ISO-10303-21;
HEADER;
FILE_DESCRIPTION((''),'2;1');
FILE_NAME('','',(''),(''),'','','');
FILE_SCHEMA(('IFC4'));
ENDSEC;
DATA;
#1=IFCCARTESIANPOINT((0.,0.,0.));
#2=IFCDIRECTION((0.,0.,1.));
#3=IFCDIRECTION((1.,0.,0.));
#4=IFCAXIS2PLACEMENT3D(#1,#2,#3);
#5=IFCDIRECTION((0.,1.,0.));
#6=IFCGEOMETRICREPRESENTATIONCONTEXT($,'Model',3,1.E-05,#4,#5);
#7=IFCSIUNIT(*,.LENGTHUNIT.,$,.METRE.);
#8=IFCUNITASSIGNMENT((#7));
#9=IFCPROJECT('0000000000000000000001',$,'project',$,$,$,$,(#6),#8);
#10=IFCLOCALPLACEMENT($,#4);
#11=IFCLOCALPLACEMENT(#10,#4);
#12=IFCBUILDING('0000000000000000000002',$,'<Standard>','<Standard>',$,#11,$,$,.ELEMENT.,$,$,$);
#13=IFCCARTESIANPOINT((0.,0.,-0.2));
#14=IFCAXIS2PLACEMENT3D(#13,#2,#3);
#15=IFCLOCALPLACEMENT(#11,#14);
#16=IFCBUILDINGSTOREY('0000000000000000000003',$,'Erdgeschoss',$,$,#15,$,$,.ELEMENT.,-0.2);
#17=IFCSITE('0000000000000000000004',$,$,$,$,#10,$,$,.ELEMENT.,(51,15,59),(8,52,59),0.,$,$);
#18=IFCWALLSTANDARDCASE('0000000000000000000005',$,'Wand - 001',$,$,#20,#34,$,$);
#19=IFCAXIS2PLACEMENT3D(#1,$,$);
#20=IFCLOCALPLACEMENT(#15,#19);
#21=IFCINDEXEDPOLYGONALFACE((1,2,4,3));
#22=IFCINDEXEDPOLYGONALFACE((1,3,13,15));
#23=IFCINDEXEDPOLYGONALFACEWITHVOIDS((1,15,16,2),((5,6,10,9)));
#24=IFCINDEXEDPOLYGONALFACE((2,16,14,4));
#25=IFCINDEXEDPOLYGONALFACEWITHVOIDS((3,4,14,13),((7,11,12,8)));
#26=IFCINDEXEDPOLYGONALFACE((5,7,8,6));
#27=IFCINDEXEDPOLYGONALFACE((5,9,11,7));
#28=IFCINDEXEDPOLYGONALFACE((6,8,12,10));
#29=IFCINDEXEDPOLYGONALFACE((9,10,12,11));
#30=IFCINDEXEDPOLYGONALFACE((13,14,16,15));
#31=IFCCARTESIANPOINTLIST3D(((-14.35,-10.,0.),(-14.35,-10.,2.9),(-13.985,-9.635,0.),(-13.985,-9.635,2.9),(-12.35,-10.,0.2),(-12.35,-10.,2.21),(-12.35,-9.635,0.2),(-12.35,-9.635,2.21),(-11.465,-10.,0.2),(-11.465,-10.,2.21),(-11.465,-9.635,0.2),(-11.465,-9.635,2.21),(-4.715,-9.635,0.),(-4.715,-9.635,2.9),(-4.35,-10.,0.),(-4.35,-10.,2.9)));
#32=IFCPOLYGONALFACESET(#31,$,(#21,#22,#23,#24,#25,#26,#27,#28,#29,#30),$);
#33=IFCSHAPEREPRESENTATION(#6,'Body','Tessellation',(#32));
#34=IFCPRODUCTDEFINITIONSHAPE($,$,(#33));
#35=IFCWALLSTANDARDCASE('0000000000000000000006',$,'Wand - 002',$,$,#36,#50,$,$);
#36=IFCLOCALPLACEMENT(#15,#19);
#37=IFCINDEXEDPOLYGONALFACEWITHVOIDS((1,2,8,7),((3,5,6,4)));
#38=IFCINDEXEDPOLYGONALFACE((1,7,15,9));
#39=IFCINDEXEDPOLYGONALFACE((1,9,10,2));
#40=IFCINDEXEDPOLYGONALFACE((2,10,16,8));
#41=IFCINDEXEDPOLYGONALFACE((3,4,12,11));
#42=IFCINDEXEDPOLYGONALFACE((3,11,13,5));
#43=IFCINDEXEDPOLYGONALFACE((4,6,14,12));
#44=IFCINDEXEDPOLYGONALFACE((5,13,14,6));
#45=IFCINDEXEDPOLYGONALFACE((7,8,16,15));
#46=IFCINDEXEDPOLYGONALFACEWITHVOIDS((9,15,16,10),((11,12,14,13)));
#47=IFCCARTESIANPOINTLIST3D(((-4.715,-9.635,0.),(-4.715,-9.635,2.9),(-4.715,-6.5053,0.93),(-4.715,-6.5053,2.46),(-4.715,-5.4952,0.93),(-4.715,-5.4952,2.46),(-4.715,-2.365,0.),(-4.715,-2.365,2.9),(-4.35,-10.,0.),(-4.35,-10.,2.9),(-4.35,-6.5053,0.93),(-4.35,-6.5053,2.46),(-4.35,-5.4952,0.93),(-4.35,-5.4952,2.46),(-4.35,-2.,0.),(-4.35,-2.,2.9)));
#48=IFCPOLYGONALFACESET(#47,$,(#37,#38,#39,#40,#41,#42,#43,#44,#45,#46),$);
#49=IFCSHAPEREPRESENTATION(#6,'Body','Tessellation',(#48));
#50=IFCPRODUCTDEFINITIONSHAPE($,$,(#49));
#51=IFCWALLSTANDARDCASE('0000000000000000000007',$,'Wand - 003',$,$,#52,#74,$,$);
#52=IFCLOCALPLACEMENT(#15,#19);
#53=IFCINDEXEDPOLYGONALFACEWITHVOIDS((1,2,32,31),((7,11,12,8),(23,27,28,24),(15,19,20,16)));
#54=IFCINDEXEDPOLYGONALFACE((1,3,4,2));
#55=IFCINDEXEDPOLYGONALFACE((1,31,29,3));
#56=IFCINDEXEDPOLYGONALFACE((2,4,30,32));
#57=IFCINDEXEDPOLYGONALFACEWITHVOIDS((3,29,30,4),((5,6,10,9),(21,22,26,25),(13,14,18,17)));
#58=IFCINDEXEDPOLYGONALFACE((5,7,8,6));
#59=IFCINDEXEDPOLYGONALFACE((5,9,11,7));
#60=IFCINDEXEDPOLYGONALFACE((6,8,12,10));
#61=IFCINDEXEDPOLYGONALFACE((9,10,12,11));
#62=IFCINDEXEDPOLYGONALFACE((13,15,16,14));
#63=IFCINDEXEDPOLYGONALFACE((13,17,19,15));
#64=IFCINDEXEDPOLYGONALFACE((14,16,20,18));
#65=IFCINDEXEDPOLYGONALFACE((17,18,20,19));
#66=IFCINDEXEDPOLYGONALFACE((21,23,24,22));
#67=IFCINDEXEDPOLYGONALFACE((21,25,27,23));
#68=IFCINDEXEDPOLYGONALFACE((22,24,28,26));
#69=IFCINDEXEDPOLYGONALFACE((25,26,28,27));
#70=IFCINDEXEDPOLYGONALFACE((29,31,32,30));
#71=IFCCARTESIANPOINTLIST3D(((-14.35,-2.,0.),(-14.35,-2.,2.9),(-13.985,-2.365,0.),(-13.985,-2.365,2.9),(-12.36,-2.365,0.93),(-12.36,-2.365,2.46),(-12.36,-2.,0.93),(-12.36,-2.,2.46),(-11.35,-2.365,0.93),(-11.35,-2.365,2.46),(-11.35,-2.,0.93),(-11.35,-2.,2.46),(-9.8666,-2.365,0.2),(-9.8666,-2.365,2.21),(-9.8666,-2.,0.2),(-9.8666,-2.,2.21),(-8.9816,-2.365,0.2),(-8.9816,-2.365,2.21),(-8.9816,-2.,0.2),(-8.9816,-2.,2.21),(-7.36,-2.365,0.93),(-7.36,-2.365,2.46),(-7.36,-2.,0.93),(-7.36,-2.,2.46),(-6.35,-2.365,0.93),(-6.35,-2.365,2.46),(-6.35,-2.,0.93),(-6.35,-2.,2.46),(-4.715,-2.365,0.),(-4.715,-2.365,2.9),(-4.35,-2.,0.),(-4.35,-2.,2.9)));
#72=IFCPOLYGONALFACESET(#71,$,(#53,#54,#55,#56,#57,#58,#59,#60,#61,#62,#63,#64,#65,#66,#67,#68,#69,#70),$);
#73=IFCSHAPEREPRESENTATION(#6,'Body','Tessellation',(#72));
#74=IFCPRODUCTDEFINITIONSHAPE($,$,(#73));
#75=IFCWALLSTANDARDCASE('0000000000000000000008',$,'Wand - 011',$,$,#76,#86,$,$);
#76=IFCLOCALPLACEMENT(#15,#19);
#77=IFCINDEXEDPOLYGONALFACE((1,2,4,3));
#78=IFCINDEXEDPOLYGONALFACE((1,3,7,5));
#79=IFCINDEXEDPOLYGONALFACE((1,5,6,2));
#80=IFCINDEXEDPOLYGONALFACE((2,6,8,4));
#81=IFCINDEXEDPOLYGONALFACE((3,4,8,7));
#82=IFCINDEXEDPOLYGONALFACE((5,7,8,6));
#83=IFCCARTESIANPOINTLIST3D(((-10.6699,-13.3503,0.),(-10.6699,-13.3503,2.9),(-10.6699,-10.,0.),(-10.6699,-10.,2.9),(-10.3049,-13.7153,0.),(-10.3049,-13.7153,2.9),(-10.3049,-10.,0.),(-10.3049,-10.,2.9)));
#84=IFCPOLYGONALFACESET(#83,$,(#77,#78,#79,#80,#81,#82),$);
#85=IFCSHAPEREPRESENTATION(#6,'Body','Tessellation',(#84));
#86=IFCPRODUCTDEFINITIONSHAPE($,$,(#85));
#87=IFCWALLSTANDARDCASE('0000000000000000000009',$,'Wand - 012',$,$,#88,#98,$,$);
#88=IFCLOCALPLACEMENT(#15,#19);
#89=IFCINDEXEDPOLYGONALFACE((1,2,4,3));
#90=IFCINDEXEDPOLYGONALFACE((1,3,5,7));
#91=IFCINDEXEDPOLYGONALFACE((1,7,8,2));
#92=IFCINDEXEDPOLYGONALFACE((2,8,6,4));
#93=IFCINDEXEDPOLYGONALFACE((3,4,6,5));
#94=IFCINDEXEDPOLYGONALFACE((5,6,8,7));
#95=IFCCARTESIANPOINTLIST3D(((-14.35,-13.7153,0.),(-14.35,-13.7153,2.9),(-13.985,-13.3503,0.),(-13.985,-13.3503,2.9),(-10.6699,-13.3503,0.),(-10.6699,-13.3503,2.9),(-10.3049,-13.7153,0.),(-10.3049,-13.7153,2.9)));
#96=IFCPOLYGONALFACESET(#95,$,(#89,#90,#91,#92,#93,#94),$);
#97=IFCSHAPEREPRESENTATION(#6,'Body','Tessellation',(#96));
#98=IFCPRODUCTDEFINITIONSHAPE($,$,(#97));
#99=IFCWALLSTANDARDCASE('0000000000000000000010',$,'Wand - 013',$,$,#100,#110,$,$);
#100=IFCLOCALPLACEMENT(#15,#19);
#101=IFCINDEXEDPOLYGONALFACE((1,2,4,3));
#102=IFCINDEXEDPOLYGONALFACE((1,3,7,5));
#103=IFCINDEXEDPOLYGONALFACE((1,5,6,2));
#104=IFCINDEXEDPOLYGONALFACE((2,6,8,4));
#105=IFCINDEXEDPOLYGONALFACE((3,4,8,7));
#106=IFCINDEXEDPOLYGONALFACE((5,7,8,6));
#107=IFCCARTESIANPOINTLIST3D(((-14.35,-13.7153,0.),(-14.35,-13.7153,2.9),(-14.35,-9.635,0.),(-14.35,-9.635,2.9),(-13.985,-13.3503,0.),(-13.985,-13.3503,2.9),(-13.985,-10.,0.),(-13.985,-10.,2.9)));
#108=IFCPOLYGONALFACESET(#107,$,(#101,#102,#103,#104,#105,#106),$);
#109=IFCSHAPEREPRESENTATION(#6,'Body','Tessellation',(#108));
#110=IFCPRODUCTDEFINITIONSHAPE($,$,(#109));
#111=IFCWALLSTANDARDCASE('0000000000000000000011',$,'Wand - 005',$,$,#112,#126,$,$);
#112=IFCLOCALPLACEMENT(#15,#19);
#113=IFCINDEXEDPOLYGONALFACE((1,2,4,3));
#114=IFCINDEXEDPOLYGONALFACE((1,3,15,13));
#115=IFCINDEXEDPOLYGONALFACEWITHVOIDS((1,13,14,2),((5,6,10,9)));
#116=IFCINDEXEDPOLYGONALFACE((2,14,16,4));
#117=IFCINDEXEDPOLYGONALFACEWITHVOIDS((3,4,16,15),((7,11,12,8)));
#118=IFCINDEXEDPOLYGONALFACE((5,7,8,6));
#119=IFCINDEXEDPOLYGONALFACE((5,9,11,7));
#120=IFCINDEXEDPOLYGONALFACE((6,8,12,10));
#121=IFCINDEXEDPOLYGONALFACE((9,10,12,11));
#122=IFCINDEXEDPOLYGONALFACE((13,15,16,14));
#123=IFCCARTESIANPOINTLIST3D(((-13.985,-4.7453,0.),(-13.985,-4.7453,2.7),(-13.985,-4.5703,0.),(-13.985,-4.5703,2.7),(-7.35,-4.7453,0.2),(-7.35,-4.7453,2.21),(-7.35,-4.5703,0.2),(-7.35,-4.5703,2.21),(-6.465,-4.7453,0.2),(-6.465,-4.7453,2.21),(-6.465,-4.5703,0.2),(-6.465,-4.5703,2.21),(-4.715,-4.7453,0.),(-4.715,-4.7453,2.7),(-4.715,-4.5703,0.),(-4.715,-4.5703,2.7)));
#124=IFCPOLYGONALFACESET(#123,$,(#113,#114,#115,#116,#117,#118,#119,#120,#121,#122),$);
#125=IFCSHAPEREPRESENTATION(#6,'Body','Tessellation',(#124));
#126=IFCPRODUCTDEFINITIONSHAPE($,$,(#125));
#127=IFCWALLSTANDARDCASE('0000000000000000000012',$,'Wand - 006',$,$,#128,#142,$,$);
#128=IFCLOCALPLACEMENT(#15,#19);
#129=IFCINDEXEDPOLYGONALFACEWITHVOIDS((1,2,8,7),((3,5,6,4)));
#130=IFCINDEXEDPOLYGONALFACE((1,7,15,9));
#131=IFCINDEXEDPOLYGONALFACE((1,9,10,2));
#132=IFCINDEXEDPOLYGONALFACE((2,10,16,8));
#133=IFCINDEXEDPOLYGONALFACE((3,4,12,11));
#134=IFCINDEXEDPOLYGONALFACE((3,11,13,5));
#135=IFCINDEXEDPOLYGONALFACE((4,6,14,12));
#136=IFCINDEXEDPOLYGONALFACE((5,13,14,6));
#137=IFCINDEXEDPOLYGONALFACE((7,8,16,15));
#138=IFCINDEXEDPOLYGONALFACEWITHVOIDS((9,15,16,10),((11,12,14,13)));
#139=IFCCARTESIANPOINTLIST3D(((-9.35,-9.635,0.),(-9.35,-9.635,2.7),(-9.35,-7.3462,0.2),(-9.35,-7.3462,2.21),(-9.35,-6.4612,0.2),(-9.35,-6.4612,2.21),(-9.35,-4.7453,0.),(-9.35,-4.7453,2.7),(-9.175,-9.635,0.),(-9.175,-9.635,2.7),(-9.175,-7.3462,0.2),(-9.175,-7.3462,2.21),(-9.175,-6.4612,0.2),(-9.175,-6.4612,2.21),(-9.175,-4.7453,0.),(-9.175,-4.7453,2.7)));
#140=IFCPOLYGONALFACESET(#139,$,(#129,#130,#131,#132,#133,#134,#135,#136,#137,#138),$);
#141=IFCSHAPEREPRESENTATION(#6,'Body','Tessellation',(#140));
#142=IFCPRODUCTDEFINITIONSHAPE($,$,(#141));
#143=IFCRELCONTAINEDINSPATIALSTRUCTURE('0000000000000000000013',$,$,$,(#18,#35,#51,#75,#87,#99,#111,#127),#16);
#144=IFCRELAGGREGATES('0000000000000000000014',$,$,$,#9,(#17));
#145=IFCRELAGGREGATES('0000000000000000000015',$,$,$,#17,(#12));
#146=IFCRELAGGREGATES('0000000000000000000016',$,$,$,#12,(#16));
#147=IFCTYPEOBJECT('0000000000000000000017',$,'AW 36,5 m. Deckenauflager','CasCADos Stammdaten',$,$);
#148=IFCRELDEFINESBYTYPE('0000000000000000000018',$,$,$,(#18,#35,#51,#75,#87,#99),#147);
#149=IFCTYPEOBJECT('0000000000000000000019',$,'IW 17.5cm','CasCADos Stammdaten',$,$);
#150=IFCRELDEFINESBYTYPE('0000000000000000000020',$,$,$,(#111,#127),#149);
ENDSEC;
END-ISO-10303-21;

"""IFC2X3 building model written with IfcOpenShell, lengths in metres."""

from ifc_helpers import new_model, si_unit, direction, frame, origin_with_axes, place, context, project, spatial, polyline, outline, extrude, type_object, element, save


model = new_model("IFC2X3")

# Units and contexts
model_context = context("Model", 3, precision=1e-05, world=origin_with_axes(), true_north=direction((0.0, 1.0, 0.0)))
ifc_project = project(units=[si_unit("LENGTHUNIT", "METRE")], contexts=[model_context])

# Site, building, storey
site_placement = place(None, origin_with_axes())
site = spatial("IfcSite", under=ifc_project, at=site_placement, CompositionType="ELEMENT", RefLatitude=(51, 15, 59), RefLongitude=(8, 52, 59), RefElevation=0.0)
building_placement = place(site_placement, origin_with_axes())
building = spatial("IfcBuilding", under=site, at=building_placement, Name="<Standard>", Description="<Standard>", CompositionType="ELEMENT")
storey_placement = place(building_placement, frame((0.0, 0.0, -0.2), z_axis=(0.0, 0.0, 1.0), x_axis=(1.0, 0.0, 0.0)))
storey = spatial("IfcBuildingStorey", under=building, at=storey_placement, Name="Erdgeschoss", CompositionType="ELEMENT", Elevation=-0.2)

# Walls, openings
ifc_type_object_1 = type_object("IfcTypeObject", Name="AW 36,5 m. Deckenauflager", Description="CasCADos Stammdaten")
wall_1_placement = place(storey_placement, frame((-14.35, -10.0, 0.0), z_axis=(0.0, 0.0, 1.0), x_axis=(1.0, 0.0, 0.0)))
wall_1 = element("IfcWallStandardCase", 1, at=wall_1_placement, inside=storey, type_object=ifc_type_object_1, Name="Wand - 001", context=model_context, shape_type="SweptSolid", body=[
    extrude(outline(polyline([(0.365, 0.365), (0.0, 0.0), (10.0, 0.0), (9.635, 0.365), (0.365, 0.365)])), origin_with_axes(), (0.0, 0.0, 1.0), 2.9),
])
opening_1_placement = place(wall_1_placement, frame((2.4425, 0.1825, 0.2), z_axis=(0.0, 0.0, 1.0), x_axis=(1.0, 0.0, 0.0)))
element("IfcOpeningElement", 2, at=opening_1_placement, cuts=wall_1, context=model_context, shape_type="SweptSolid", body=[
    extrude(outline(polyline([(0.0, 0.4425), (0.0, -0.4425), (2.01, -0.4425), (2.01, 0.4425), (0.0, 0.4425)])), frame((0.0, -0.1825, 0.0), z_axis=(0.0, 1.0, 0.0), x_axis=(0.0, 0.0, 1.0)), (0.0, 0.0, 1.0), 0.365),
])
wall_2_placement = place(storey_placement, frame((-4.35, -10.0, 0.0), z_axis=(0.0, 0.0, 1.0), x_axis=(0.0, 1.0, 0.0)))
wall_2 = element("IfcWallStandardCase", 3, at=wall_2_placement, inside=storey, type_object=ifc_type_object_1, Name="Wand - 002", context=model_context, shape_type="SweptSolid", body=[
    extrude(outline(polyline([(0.365, 0.365), (0.0, 0.0), (8.0, 0.0), (7.635, 0.365), (0.365, 0.365)])), origin_with_axes(), (0.0, 0.0, 1.0), 2.9),
])
opening_2_placement = place(wall_2_placement, frame((3.9998, 0.1825, 0.2), z_axis=(0.0, 0.0, 1.0), x_axis=(1.0, 0.0, 0.0)))
element("IfcOpeningElement", 4, at=opening_2_placement, cuts=wall_2, context=model_context, shape_type="SweptSolid", body=[
    extrude(outline(polyline([(0.73, 0.505), (0.73, -0.505), (2.26, -0.505), (2.26, 0.505), (0.73, 0.505)])), frame((0.0, -0.1825, 0.0), z_axis=(0.0, 1.0, 0.0), x_axis=(0.0, 0.0, 1.0)), (0.0, 0.0, 1.0), 0.365),
])

# Wall, openings
wall_3_placement = place(storey_placement, frame((-4.35, -2.0, 0.0), z_axis=(0.0, 0.0, 1.0), x_axis=(-1.0, 0.0, 0.0)))
wall_3 = element("IfcWallStandardCase", 5, at=wall_3_placement, inside=storey, type_object=ifc_type_object_1, Name="Wand - 003", context=model_context, shape_type="SweptSolid", body=[
    extrude(outline(polyline([(0.365, 0.365), (0.0, 0.0), (10.0, 0.0), (9.635, 0.365), (0.365, 0.365)])), origin_with_axes(), (0.0, 0.0, 1.0), 2.9),
])
opening_3_placement = place(wall_3_placement, frame((5.0741, 0.1825, 0.2), z_axis=(0.0, 0.0, 1.0), x_axis=(1.0, 0.0, 0.0)))
element("IfcOpeningElement", 6, at=opening_3_placement, cuts=wall_3, context=model_context, shape_type="SweptSolid", body=[
    extrude(outline(polyline([(0.0, 0.4425), (0.0, -0.4425), (2.01, -0.4425), (2.01, 0.4425), (0.0, 0.4425)])), frame((0.0, -0.1825, 0.0), z_axis=(0.0, 1.0, 0.0), x_axis=(0.0, 0.0, 1.0)), (0.0, 0.0, 1.0), 0.365),
])
opening_4_placement = place(wall_3_placement, frame((7.505, 0.1825, 0.2), z_axis=(0.0, 0.0, 1.0), x_axis=(1.0, 0.0, 0.0)))
element("IfcOpeningElement", 7, at=opening_4_placement, cuts=wall_3, context=model_context, shape_type="SweptSolid", body=[
    extrude(outline(polyline([(0.73, 0.505), (0.73, -0.505), (2.26, -0.505), (2.26, 0.505), (0.73, 0.505)])), frame((0.0, -0.1825, 0.0), z_axis=(0.0, 1.0, 0.0), x_axis=(0.0, 0.0, 1.0)), (0.0, 0.0, 1.0), 0.365),
])
opening_5_placement = place(wall_3_placement, frame((2.505, 0.1825, 0.2), z_axis=(0.0, 0.0, 1.0), x_axis=(1.0, 0.0, 0.0)))
element("IfcOpeningElement", 8, at=opening_5_placement, cuts=wall_3, context=model_context, shape_type="SweptSolid", body=[
    extrude(outline(polyline([(0.73, 0.505), (0.73, -0.505), (2.26, -0.505), (2.26, 0.505), (0.73, 0.505)])), frame((0.0, -0.1825, 0.0), z_axis=(0.0, 1.0, 0.0), x_axis=(0.0, 0.0, 1.0)), (0.0, 0.0, 1.0), 0.365),
])

# Walls
wall_4_placement = place(storey_placement, frame((-10.6699, -10.0, 0.0), z_axis=(0.0, 0.0, 1.0), x_axis=(0.0, -1.0, 0.0)))
element("IfcWallStandardCase", 9, at=wall_4_placement, inside=storey, type_object=ifc_type_object_1, Name="Wand - 011", context=model_context, shape_type="SweptSolid", body=[
    extrude(outline(polyline([(0.0, 0.365), (0.0, 0.0), (3.3503, 0.0), (3.7153, 0.365), (0.0, 0.365)])), origin_with_axes(), (0.0, 0.0, 1.0), 2.9),
])
wall_5_placement = place(storey_placement, frame((-10.6699, -13.3503, 0.0), z_axis=(0.0, 0.0, 1.0), x_axis=(-1.0, 0.0, 0.0)))
element("IfcWallStandardCase", 10, at=wall_5_placement, inside=storey, type_object=ifc_type_object_1, Name="Wand - 012", context=model_context, shape_type="SweptSolid", body=[
    extrude(outline(polyline([(-0.365, 0.365), (0.0, 0.0), (3.3151, 0.0), (3.6801, 0.365), (-0.365, 0.365)])), origin_with_axes(), (0.0, 0.0, 1.0), 2.9),
])
wall_6_placement = place(storey_placement, frame((-13.985, -13.3503, 0.0), z_axis=(0.0, 0.0, 1.0), x_axis=(0.0, 1.0, 0.0)))
element("IfcWallStandardCase", 11, at=wall_6_placement, inside=storey, type_object=ifc_type_object_1, Name="Wand - 013", context=model_context, shape_type="SweptSolid", body=[
    extrude(outline(polyline([(-0.365, 0.365), (0.0, 0.0), (3.3503, 0.0), (3.7153, 0.365), (-0.365, 0.365)])), origin_with_axes(), (0.0, 0.0, 1.0), 2.9),
])

# Walls, openings
ifc_type_object_2 = type_object("IfcTypeObject", Name="IW 17.5cm", Description="CasCADos Stammdaten")
wall_7_placement = place(storey_placement, frame((-13.985, -4.7453, 0.0), z_axis=(0.0, 0.0, 1.0), x_axis=(1.0, 0.0, 0.0)))
wall_7 = element("IfcWallStandardCase", 12, at=wall_7_placement, inside=storey, type_object=ifc_type_object_2, Name="Wand - 005", context=model_context, shape_type="SweptSolid", body=[
    extrude(outline(polyline([(0.0, 0.175), (0.0, 0.0), (9.27, 0.0), (9.27, 0.175), (0.0, 0.175)])), origin_with_axes(), (0.0, 0.0, 1.0), 2.7),
])
opening_6_placement = place(wall_7_placement, frame((7.0775, 0.0875, 0.2), z_axis=(0.0, 0.0, 1.0), x_axis=(1.0, 0.0, 0.0)))
element("IfcOpeningElement", 13, at=opening_6_placement, cuts=wall_7, context=model_context, shape_type="SweptSolid", body=[
    extrude(outline(polyline([(0.0, 0.4425), (0.0, -0.4425), (2.01, -0.4425), (2.01, 0.4425), (0.0, 0.4425)])), frame((0.0, -0.0875, 0.0), z_axis=(0.0, 1.0, 0.0), x_axis=(0.0, 0.0, 1.0)), (0.0, 0.0, 1.0), 0.175),
])
wall_8_placement = place(storey_placement, frame((-9.35, -4.7453, 0.0), z_axis=(0.0, 0.0, 1.0), x_axis=(0.0, -1.0, 0.0)))
wall_8 = element("IfcWallStandardCase", 14, at=wall_8_placement, inside=storey, type_object=ifc_type_object_2, Name="Wand - 006", context=model_context, shape_type="SweptSolid", body=[
    extrude(outline(polyline([(0.0, 0.175), (0.0, 0.0), (4.8897, 0.0), (4.8897, 0.175), (0.0, 0.175)])), origin_with_axes(), (0.0, 0.0, 1.0), 2.7),
])
opening_7_placement = place(wall_8_placement, frame((2.1584, 0.0875, 0.2), z_axis=(0.0, 0.0, 1.0), x_axis=(1.0, 0.0, 0.0)))
element("IfcOpeningElement", 15, at=opening_7_placement, cuts=wall_8, context=model_context, shape_type="SweptSolid", body=[
    extrude(outline(polyline([(0.0, 0.4425), (0.0, -0.4425), (2.01, -0.4425), (2.01, 0.4425), (0.0, 0.4425)])), frame((0.0, -0.0875, 0.0), z_axis=(0.0, 1.0, 0.0), x_axis=(0.0, 0.0, 1.0)), (0.0, 0.0, 1.0), 0.175),
])

save(model, "model.ifc")
